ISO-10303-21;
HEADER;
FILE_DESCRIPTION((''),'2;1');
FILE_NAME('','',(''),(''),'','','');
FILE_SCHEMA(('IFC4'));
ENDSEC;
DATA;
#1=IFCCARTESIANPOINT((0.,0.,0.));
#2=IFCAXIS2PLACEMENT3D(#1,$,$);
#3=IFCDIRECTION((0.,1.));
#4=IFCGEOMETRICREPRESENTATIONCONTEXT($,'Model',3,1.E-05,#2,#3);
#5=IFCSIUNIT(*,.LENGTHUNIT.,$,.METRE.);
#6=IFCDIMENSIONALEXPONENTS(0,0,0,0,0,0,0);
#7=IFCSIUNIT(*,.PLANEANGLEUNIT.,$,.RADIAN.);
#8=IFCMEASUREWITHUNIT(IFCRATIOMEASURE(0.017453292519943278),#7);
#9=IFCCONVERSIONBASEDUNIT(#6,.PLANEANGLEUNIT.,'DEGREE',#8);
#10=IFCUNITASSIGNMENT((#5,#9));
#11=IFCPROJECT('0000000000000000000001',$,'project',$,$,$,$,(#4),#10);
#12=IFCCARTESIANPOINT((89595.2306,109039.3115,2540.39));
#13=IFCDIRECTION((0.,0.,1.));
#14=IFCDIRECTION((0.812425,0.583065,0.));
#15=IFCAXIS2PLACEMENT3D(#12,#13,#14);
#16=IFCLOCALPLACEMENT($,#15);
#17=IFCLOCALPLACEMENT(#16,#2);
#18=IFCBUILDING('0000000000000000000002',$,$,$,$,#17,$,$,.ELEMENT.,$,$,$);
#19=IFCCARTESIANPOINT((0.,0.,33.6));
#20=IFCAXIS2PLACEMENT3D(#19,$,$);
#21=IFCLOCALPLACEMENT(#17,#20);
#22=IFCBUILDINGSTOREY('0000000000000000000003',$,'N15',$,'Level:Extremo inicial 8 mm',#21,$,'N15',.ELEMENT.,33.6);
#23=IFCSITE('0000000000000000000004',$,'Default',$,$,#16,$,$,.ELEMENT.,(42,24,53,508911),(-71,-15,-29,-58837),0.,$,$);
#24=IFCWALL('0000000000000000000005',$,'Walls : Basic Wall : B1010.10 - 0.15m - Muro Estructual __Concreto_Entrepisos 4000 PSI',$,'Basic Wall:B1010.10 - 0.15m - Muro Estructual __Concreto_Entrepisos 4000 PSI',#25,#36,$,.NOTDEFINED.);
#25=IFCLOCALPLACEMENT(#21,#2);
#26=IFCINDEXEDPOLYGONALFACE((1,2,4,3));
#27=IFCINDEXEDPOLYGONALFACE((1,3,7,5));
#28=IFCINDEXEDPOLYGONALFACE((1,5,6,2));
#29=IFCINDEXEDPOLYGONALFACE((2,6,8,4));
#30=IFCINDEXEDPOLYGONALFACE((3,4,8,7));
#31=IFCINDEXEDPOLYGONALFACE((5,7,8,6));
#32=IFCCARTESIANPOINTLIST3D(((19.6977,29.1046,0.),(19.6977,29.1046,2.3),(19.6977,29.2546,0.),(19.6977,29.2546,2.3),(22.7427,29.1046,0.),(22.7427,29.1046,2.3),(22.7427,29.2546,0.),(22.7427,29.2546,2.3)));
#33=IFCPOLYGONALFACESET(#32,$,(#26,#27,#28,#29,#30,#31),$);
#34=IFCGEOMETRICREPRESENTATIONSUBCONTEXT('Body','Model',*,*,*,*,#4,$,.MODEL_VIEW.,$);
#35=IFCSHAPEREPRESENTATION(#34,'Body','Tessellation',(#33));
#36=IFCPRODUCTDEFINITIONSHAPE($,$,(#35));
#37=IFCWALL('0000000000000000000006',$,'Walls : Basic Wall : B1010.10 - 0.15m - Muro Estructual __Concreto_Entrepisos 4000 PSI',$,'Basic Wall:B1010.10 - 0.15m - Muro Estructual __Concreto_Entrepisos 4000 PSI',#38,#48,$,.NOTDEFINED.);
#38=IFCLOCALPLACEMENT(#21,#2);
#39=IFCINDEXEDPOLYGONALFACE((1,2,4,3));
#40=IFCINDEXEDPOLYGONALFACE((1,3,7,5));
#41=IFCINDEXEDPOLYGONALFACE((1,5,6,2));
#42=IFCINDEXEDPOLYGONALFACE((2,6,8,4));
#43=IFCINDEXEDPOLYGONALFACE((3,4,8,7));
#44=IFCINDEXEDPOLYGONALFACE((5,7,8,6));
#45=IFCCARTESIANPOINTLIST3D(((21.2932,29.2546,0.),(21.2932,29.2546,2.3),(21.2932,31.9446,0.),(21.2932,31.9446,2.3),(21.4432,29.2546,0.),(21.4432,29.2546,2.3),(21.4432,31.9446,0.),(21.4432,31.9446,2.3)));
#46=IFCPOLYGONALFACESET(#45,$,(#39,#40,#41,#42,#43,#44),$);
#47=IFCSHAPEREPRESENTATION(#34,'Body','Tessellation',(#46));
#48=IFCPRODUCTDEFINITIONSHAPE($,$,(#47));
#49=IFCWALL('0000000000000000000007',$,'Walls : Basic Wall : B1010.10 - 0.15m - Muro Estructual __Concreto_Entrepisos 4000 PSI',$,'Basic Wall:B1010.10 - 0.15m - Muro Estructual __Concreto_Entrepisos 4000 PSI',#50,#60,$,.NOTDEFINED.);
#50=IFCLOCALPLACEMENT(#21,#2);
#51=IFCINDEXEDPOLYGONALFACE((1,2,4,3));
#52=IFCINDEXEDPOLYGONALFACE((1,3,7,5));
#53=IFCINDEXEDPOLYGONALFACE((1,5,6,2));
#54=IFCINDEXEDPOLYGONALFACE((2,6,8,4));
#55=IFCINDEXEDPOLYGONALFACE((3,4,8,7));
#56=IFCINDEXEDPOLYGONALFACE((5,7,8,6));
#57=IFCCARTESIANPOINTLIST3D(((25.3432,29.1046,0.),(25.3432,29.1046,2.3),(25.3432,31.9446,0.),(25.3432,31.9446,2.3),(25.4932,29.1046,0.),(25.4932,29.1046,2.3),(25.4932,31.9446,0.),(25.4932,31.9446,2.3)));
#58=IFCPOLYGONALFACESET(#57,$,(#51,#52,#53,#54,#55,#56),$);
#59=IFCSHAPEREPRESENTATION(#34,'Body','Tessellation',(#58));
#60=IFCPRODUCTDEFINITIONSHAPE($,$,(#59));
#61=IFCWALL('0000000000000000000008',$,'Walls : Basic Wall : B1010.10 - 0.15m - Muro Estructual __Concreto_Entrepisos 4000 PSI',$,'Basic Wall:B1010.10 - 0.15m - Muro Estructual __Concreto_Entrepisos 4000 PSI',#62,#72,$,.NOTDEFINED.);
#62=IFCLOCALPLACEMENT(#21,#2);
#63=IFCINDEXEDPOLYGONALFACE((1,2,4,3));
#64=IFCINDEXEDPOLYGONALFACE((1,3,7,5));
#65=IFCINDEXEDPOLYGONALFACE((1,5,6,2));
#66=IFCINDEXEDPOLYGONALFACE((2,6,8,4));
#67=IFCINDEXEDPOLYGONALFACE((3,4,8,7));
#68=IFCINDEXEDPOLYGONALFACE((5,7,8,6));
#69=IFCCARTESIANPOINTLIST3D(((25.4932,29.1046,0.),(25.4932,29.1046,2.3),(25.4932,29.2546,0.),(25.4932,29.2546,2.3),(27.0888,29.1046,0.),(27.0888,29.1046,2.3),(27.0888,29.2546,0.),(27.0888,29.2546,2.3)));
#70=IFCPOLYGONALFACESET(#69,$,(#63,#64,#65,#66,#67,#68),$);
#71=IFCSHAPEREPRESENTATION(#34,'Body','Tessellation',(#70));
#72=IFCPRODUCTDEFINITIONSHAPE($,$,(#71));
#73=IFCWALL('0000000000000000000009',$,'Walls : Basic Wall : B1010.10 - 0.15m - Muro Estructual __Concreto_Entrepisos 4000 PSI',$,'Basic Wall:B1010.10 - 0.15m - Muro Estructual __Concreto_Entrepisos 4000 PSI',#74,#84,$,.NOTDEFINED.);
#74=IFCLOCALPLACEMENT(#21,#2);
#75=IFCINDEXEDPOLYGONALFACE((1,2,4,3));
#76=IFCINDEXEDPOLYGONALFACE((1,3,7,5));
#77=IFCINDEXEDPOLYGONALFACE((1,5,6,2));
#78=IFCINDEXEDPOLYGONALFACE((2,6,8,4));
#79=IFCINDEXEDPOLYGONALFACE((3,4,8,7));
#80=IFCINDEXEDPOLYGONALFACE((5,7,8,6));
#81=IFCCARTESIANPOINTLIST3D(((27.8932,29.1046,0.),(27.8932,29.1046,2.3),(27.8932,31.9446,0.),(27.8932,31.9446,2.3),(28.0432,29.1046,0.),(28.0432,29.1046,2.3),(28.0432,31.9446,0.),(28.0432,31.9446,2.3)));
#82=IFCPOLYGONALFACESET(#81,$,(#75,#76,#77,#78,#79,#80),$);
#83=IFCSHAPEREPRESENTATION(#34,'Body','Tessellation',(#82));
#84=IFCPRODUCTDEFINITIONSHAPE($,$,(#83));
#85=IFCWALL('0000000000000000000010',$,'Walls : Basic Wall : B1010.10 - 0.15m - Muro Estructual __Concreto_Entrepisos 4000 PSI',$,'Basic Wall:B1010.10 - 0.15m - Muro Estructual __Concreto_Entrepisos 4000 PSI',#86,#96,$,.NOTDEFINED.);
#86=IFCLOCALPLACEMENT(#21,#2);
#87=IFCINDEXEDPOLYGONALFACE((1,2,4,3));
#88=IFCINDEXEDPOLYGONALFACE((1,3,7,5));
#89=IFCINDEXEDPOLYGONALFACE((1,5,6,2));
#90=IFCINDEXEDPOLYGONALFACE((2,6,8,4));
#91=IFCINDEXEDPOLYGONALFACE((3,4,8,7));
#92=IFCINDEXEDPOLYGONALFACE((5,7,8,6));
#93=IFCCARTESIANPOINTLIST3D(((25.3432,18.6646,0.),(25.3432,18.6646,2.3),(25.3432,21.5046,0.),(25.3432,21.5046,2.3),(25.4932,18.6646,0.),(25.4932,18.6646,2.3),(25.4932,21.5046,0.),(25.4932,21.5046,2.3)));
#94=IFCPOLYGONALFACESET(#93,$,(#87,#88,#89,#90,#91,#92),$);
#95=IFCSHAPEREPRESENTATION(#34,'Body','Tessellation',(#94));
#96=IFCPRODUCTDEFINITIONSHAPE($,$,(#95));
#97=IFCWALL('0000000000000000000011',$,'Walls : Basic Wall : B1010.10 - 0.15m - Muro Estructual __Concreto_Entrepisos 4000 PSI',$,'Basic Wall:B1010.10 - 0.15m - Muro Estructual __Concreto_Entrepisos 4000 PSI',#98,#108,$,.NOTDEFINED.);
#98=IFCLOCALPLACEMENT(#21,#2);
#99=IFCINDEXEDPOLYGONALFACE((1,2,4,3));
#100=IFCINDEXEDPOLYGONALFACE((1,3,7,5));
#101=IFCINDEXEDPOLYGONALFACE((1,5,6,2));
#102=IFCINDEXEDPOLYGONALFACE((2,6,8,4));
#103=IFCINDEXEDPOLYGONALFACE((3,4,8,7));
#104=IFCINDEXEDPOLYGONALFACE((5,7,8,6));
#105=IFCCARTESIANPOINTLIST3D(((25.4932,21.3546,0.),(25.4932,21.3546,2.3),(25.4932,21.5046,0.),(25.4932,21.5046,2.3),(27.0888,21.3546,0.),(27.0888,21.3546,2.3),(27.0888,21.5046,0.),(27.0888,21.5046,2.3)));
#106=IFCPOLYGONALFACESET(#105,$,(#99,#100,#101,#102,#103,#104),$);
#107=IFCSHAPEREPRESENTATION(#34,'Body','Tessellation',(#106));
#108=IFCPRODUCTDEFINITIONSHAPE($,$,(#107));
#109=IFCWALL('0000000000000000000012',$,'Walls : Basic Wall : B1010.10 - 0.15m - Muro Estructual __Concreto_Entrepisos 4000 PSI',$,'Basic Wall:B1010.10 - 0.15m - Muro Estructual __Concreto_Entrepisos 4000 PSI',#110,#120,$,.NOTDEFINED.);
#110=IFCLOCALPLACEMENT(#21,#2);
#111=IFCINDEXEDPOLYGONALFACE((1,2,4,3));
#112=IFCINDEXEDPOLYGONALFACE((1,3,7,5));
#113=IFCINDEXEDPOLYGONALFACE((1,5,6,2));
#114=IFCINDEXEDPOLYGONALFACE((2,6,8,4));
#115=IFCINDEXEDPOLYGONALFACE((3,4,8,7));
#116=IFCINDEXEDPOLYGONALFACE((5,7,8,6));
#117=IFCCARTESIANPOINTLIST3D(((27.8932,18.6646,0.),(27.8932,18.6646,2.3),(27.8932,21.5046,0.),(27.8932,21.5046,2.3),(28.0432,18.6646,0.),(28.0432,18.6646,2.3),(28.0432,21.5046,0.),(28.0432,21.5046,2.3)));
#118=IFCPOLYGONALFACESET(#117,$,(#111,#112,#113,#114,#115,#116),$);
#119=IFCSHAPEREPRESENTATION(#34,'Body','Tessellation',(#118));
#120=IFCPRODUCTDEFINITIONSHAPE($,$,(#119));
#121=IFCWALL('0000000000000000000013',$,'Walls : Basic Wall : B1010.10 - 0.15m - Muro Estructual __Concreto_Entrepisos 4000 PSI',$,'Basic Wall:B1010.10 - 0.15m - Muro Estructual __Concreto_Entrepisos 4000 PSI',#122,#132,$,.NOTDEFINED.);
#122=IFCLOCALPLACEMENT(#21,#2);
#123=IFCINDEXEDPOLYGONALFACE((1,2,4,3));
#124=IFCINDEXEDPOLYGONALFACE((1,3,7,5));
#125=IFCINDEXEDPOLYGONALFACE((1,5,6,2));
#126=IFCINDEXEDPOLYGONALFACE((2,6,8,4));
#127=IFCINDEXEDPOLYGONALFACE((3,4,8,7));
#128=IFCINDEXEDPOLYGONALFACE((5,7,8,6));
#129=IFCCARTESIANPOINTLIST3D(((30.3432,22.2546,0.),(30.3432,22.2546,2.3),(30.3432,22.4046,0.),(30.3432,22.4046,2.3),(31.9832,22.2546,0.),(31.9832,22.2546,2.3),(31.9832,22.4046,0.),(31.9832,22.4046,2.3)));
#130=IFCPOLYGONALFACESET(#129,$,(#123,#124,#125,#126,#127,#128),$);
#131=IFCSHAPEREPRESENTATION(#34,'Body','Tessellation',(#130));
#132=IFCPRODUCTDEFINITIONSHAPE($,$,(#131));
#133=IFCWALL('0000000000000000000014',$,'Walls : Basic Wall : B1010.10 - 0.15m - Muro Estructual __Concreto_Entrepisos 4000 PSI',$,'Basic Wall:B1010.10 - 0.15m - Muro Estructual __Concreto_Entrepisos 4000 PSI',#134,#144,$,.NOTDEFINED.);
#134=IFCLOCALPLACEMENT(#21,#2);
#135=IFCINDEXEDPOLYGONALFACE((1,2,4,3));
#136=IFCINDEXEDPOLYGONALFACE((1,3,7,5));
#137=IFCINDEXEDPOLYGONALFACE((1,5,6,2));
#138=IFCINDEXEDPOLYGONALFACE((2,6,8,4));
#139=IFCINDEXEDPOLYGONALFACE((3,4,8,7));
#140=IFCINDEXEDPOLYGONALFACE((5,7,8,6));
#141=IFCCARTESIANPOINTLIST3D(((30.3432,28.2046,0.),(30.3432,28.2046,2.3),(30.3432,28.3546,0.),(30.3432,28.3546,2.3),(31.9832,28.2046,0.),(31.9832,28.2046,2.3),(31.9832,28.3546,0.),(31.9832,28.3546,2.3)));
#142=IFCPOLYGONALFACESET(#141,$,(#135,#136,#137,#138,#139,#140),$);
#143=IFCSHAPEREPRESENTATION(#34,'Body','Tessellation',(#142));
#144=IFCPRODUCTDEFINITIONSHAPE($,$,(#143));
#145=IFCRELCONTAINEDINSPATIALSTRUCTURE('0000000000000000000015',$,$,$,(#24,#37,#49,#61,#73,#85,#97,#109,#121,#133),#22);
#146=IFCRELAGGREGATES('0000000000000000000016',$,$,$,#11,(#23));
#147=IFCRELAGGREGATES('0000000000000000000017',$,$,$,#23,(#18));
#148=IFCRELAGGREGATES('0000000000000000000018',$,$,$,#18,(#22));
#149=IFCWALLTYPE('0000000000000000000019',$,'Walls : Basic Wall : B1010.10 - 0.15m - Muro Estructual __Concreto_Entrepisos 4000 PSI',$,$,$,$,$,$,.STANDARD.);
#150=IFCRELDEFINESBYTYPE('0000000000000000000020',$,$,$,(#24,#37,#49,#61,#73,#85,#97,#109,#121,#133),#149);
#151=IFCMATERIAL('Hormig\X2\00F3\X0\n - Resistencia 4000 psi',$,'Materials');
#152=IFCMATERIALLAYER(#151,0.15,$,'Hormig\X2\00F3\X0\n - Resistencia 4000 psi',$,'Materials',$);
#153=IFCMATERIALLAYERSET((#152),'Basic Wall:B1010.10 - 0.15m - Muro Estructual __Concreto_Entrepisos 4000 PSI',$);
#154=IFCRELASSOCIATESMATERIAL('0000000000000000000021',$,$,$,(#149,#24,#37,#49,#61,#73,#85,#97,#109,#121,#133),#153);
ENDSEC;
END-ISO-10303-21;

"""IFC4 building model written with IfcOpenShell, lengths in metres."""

from ifc_helpers import new_model, entity, si_unit, converted_unit, direction, frame, frame_2d, origin, place, context, subcontext, project, spatial, rectangle, extrude, material, layer, layer_set, layer_usage, type_object, element, save


model = new_model("IFC4")

# Units and contexts
model_context = context("Model", 3, precision=1e-05, world=origin(), true_north=direction((0.0, 1.0)))
body_context = subcontext(model_context, "Body", "Model", "MODEL_VIEW")
ifc_project = project(units=[si_unit("LENGTHUNIT", "METRE"), converted_unit("PLANEANGLEUNIT", "DEGREE", entity("IfcRatioMeasure", 0.017453292519943278), si_unit("PLANEANGLEUNIT", "RADIAN"), dimensions=[0, 0, 0, 0, 0, 0, 0])], contexts=[model_context])

# Site, building, storey
site_placement = place(None, frame((89595.2306, 109039.3115, 2540.39), z_axis=(0.0, 0.0, 1.0), x_axis=(0.812425, 0.583065, 0.0)))
site = spatial("IfcSite", under=ifc_project, at=site_placement, Name="Default", CompositionType="ELEMENT", RefLatitude=(42, 24, 53, 508911), RefLongitude=(-71, -15, -29, -58837), RefElevation=0.0)
building_placement = place(site_placement, origin())
building = spatial("IfcBuilding", under=site, at=building_placement, CompositionType="ELEMENT")
storey_placement = place(building_placement, frame((0.0, 0.0, 33.6)))
storey = spatial("IfcBuildingStorey", under=building, at=storey_placement, Name="N15", ObjectType="Level:Extremo inicial 8 mm", LongName="N15", CompositionType="ELEMENT", Elevation=33.6)

# Walls
ifc_material_1 = material(Name="Hormigón - Resistencia 4000 psi", Category="Materials")
ifc_layer_1 = layer(ifc_material_1, 0.15, Name="Hormigón - Resistencia 4000 psi", Category="Materials")
ifc_layer_set_1 = layer_set([ifc_layer_1], Name="Basic Wall:B1010.10 - 0.15m - Muro Estructual __Concreto_Entrepisos 4000 PSI")
wall_type_1 = type_object("IfcWallType", Name="Walls : Basic Wall : B1010.10 - 0.15m - Muro Estructual __Concreto_Entrepisos 4000 PSI", PredefinedType="STANDARD", material=ifc_layer_set_1)
ifc_layer_usage_1 = layer_usage(ifc_layer_set_1, "AXIS2", "NEGATIVE", 0.075)
wall_1_placement = place(storey_placement, frame((19.6977, 29.1796, 0.0)))
element("IfcWall", 1, at=wall_1_placement, inside=storey, type_object=wall_type_1, material=ifc_layer_usage_1, Name="Walls : Basic Wall : B1010.10 - 0.15m - Muro Estructual __Concreto_Entrepisos 4000 PSI", ObjectType="Basic Wall:B1010.10 - 0.15m - Muro Estructual __Concreto_Entrepisos 4000 PSI", PredefinedType="NOTDEFINED", context=body_context, shape_type="SweptSolid", body=[
    extrude(rectangle(XDim=3.045, YDim=0.15, at=frame_2d((1.5225, 0.0), x_axis=(-1.0, 0.0))), origin(), (0.0, 0.0, 1.0), 2.3),
])
ifc_layer_usage_2 = layer_usage(ifc_layer_set_1, "AXIS2", "NEGATIVE", 0.075)
wall_2_placement = place(storey_placement, frame((21.3682, 31.9446, 0.0), z_axis=(0.0, 0.0, 1.0), x_axis=(0.0, -1.0, 0.0)))
element("IfcWall", 2, at=wall_2_placement, inside=storey, type_object=wall_type_1, material=ifc_layer_usage_2, Name="Walls : Basic Wall : B1010.10 - 0.15m - Muro Estructual __Concreto_Entrepisos 4000 PSI", ObjectType="Basic Wall:B1010.10 - 0.15m - Muro Estructual __Concreto_Entrepisos 4000 PSI", PredefinedType="NOTDEFINED", context=body_context, shape_type="SweptSolid", body=[
    extrude(rectangle(XDim=2.69, YDim=0.15, at=frame_2d((1.345, 0.0), x_axis=(-1.0, 0.0))), origin(), (0.0, 0.0, 1.0), 2.3),
])
ifc_layer_usage_3 = layer_usage(ifc_layer_set_1, "AXIS2", "NEGATIVE", 0.075)
wall_3_placement = place(storey_placement, frame((25.4182, 31.9446, 0.0), z_axis=(0.0, 0.0, 1.0), x_axis=(0.0, -1.0, 0.0)))
element("IfcWall", 3, at=wall_3_placement, inside=storey, type_object=wall_type_1, material=ifc_layer_usage_3, Name="Walls : Basic Wall : B1010.10 - 0.15m - Muro Estructual __Concreto_Entrepisos 4000 PSI", ObjectType="Basic Wall:B1010.10 - 0.15m - Muro Estructual __Concreto_Entrepisos 4000 PSI", PredefinedType="NOTDEFINED", context=body_context, shape_type="SweptSolid", body=[
    extrude(rectangle(XDim=2.84, YDim=0.15, at=frame_2d((1.42, 0.0), x_axis=(-1.0, 0.0))), origin(), (0.0, 0.0, 1.0), 2.3),
])
ifc_layer_usage_4 = layer_usage(ifc_layer_set_1, "AXIS2", "NEGATIVE", 0.075)
wall_4_placement = place(storey_placement, frame((27.0888, 29.1796, 0.0), z_axis=(0.0, 0.0, 1.0), x_axis=(-1.0, 0.0, 0.0)))
element("IfcWall", 4, at=wall_4_placement, inside=storey, type_object=wall_type_1, material=ifc_layer_usage_4, Name="Walls : Basic Wall : B1010.10 - 0.15m - Muro Estructual __Concreto_Entrepisos 4000 PSI", ObjectType="Basic Wall:B1010.10 - 0.15m - Muro Estructual __Concreto_Entrepisos 4000 PSI", PredefinedType="NOTDEFINED", context=body_context, shape_type="SweptSolid", body=[
    extrude(rectangle(XDim=1.5955, YDim=0.15, at=frame_2d((0.7978, 0.0), x_axis=(-1.0, 0.0))), origin(), (0.0, 0.0, 1.0), 2.3),
])
ifc_layer_usage_5 = layer_usage(ifc_layer_set_1, "AXIS2", "NEGATIVE", 0.075)
wall_5_placement = place(storey_placement, frame((27.9682, 31.9446, 0.0), z_axis=(0.0, 0.0, 1.0), x_axis=(0.0, -1.0, 0.0)))
element("IfcWall", 5, at=wall_5_placement, inside=storey, type_object=wall_type_1, material=ifc_layer_usage_5, Name="Walls : Basic Wall : B1010.10 - 0.15m - Muro Estructual __Concreto_Entrepisos 4000 PSI", ObjectType="Basic Wall:B1010.10 - 0.15m - Muro Estructual __Concreto_Entrepisos 4000 PSI", PredefinedType="NOTDEFINED", context=body_context, shape_type="SweptSolid", body=[
    extrude(rectangle(XDim=2.84, YDim=0.15, at=frame_2d((1.42, 0.0), x_axis=(-1.0, 0.0))), origin(), (0.0, 0.0, 1.0), 2.3),
])
ifc_layer_usage_6 = layer_usage(ifc_layer_set_1, "AXIS2", "NEGATIVE", 0.075)
wall_6_placement = place(storey_placement, frame((25.4182, 18.6646, 0.0), z_axis=(0.0, 0.0, 1.0), x_axis=(0.0, 1.0, 0.0)))
element("IfcWall", 6, at=wall_6_placement, inside=storey, type_object=wall_type_1, material=ifc_layer_usage_6, Name="Walls : Basic Wall : B1010.10 - 0.15m - Muro Estructual __Concreto_Entrepisos 4000 PSI", ObjectType="Basic Wall:B1010.10 - 0.15m - Muro Estructual __Concreto_Entrepisos 4000 PSI", PredefinedType="NOTDEFINED", context=body_context, shape_type="SweptSolid", body=[
    extrude(rectangle(XDim=2.84, YDim=0.15, at=frame_2d((1.42, 0.0), x_axis=(-1.0, 0.0))), origin(), (0.0, 0.0, 1.0), 2.3),
])
ifc_layer_usage_7 = layer_usage(ifc_layer_set_1, "AXIS2", "NEGATIVE", 0.075)
wall_7_placement = place(storey_placement, frame((27.0888, 21.4296, 0.0), z_axis=(0.0, 0.0, 1.0), x_axis=(-1.0, 0.0, 0.0)))
element("IfcWall", 7, at=wall_7_placement, inside=storey, type_object=wall_type_1, material=ifc_layer_usage_7, Name="Walls : Basic Wall : B1010.10 - 0.15m - Muro Estructual __Concreto_Entrepisos 4000 PSI", ObjectType="Basic Wall:B1010.10 - 0.15m - Muro Estructual __Concreto_Entrepisos 4000 PSI", PredefinedType="NOTDEFINED", context=body_context, shape_type="SweptSolid", body=[
    extrude(rectangle(XDim=1.5955, YDim=0.15, at=frame_2d((0.7978, 0.0), x_axis=(-1.0, 0.0))), origin(), (0.0, 0.0, 1.0), 2.3),
])
ifc_layer_usage_8 = layer_usage(ifc_layer_set_1, "AXIS2", "NEGATIVE", 0.075)
wall_8_placement = place(storey_placement, frame((27.9682, 18.6646, 0.0), z_axis=(0.0, 0.0, 1.0), x_axis=(0.0, 1.0, 0.0)))
element("IfcWall", 8, at=wall_8_placement, inside=storey, type_object=wall_type_1, material=ifc_layer_usage_8, Name="Walls : Basic Wall : B1010.10 - 0.15m - Muro Estructual __Concreto_Entrepisos 4000 PSI", ObjectType="Basic Wall:B1010.10 - 0.15m - Muro Estructual __Concreto_Entrepisos 4000 PSI", PredefinedType="NOTDEFINED", context=body_context, shape_type="SweptSolid", body=[
    extrude(rectangle(XDim=2.84, YDim=0.15, at=frame_2d((1.42, 0.0), x_axis=(-1.0, 0.0))), origin(), (0.0, 0.0, 1.0), 2.3),
])
ifc_layer_usage_9 = layer_usage(ifc_layer_set_1, "AXIS2", "NEGATIVE", 0.075)
wall_9_placement = place(storey_placement, frame((31.9832, 22.3296, 0.0), z_axis=(0.0, 0.0, 1.0), x_axis=(-1.0, 0.0, 0.0)))
element("IfcWall", 9, at=wall_9_placement, inside=storey, type_object=wall_type_1, material=ifc_layer_usage_9, Name="Walls : Basic Wall : B1010.10 - 0.15m - Muro Estructual __Concreto_Entrepisos 4000 PSI", ObjectType="Basic Wall:B1010.10 - 0.15m - Muro Estructual __Concreto_Entrepisos 4000 PSI", PredefinedType="NOTDEFINED", context=body_context, shape_type="SweptSolid", body=[
    extrude(rectangle(XDim=1.64, YDim=0.15, at=frame_2d((0.82, 0.0), x_axis=(-1.0, 0.0))), origin(), (0.0, 0.0, 1.0), 2.3),
])
ifc_layer_usage_10 = layer_usage(ifc_layer_set_1, "AXIS2", "POSITIVE", -0.075)
wall_10_placement = place(storey_placement, frame((31.9832, 28.2796, 0.0), z_axis=(0.0, 0.0, 1.0), x_axis=(-1.0, 0.0, 0.0)))
element("IfcWall", 10, at=wall_10_placement, inside=storey, type_object=wall_type_1, material=ifc_layer_usage_10, Name="Walls : Basic Wall : B1010.10 - 0.15m - Muro Estructual __Concreto_Entrepisos 4000 PSI", ObjectType="Basic Wall:B1010.10 - 0.15m - Muro Estructual __Concreto_Entrepisos 4000 PSI", PredefinedType="NOTDEFINED", context=body_context, shape_type="SweptSolid", body=[
    extrude(rectangle(XDim=1.64, YDim=0.15, at=frame_2d((0.82, 0.0), x_axis=(-1.0, 0.0))), origin(), (0.0, 0.0, 1.0), 2.3),
])

save(model, "model.ifc")
